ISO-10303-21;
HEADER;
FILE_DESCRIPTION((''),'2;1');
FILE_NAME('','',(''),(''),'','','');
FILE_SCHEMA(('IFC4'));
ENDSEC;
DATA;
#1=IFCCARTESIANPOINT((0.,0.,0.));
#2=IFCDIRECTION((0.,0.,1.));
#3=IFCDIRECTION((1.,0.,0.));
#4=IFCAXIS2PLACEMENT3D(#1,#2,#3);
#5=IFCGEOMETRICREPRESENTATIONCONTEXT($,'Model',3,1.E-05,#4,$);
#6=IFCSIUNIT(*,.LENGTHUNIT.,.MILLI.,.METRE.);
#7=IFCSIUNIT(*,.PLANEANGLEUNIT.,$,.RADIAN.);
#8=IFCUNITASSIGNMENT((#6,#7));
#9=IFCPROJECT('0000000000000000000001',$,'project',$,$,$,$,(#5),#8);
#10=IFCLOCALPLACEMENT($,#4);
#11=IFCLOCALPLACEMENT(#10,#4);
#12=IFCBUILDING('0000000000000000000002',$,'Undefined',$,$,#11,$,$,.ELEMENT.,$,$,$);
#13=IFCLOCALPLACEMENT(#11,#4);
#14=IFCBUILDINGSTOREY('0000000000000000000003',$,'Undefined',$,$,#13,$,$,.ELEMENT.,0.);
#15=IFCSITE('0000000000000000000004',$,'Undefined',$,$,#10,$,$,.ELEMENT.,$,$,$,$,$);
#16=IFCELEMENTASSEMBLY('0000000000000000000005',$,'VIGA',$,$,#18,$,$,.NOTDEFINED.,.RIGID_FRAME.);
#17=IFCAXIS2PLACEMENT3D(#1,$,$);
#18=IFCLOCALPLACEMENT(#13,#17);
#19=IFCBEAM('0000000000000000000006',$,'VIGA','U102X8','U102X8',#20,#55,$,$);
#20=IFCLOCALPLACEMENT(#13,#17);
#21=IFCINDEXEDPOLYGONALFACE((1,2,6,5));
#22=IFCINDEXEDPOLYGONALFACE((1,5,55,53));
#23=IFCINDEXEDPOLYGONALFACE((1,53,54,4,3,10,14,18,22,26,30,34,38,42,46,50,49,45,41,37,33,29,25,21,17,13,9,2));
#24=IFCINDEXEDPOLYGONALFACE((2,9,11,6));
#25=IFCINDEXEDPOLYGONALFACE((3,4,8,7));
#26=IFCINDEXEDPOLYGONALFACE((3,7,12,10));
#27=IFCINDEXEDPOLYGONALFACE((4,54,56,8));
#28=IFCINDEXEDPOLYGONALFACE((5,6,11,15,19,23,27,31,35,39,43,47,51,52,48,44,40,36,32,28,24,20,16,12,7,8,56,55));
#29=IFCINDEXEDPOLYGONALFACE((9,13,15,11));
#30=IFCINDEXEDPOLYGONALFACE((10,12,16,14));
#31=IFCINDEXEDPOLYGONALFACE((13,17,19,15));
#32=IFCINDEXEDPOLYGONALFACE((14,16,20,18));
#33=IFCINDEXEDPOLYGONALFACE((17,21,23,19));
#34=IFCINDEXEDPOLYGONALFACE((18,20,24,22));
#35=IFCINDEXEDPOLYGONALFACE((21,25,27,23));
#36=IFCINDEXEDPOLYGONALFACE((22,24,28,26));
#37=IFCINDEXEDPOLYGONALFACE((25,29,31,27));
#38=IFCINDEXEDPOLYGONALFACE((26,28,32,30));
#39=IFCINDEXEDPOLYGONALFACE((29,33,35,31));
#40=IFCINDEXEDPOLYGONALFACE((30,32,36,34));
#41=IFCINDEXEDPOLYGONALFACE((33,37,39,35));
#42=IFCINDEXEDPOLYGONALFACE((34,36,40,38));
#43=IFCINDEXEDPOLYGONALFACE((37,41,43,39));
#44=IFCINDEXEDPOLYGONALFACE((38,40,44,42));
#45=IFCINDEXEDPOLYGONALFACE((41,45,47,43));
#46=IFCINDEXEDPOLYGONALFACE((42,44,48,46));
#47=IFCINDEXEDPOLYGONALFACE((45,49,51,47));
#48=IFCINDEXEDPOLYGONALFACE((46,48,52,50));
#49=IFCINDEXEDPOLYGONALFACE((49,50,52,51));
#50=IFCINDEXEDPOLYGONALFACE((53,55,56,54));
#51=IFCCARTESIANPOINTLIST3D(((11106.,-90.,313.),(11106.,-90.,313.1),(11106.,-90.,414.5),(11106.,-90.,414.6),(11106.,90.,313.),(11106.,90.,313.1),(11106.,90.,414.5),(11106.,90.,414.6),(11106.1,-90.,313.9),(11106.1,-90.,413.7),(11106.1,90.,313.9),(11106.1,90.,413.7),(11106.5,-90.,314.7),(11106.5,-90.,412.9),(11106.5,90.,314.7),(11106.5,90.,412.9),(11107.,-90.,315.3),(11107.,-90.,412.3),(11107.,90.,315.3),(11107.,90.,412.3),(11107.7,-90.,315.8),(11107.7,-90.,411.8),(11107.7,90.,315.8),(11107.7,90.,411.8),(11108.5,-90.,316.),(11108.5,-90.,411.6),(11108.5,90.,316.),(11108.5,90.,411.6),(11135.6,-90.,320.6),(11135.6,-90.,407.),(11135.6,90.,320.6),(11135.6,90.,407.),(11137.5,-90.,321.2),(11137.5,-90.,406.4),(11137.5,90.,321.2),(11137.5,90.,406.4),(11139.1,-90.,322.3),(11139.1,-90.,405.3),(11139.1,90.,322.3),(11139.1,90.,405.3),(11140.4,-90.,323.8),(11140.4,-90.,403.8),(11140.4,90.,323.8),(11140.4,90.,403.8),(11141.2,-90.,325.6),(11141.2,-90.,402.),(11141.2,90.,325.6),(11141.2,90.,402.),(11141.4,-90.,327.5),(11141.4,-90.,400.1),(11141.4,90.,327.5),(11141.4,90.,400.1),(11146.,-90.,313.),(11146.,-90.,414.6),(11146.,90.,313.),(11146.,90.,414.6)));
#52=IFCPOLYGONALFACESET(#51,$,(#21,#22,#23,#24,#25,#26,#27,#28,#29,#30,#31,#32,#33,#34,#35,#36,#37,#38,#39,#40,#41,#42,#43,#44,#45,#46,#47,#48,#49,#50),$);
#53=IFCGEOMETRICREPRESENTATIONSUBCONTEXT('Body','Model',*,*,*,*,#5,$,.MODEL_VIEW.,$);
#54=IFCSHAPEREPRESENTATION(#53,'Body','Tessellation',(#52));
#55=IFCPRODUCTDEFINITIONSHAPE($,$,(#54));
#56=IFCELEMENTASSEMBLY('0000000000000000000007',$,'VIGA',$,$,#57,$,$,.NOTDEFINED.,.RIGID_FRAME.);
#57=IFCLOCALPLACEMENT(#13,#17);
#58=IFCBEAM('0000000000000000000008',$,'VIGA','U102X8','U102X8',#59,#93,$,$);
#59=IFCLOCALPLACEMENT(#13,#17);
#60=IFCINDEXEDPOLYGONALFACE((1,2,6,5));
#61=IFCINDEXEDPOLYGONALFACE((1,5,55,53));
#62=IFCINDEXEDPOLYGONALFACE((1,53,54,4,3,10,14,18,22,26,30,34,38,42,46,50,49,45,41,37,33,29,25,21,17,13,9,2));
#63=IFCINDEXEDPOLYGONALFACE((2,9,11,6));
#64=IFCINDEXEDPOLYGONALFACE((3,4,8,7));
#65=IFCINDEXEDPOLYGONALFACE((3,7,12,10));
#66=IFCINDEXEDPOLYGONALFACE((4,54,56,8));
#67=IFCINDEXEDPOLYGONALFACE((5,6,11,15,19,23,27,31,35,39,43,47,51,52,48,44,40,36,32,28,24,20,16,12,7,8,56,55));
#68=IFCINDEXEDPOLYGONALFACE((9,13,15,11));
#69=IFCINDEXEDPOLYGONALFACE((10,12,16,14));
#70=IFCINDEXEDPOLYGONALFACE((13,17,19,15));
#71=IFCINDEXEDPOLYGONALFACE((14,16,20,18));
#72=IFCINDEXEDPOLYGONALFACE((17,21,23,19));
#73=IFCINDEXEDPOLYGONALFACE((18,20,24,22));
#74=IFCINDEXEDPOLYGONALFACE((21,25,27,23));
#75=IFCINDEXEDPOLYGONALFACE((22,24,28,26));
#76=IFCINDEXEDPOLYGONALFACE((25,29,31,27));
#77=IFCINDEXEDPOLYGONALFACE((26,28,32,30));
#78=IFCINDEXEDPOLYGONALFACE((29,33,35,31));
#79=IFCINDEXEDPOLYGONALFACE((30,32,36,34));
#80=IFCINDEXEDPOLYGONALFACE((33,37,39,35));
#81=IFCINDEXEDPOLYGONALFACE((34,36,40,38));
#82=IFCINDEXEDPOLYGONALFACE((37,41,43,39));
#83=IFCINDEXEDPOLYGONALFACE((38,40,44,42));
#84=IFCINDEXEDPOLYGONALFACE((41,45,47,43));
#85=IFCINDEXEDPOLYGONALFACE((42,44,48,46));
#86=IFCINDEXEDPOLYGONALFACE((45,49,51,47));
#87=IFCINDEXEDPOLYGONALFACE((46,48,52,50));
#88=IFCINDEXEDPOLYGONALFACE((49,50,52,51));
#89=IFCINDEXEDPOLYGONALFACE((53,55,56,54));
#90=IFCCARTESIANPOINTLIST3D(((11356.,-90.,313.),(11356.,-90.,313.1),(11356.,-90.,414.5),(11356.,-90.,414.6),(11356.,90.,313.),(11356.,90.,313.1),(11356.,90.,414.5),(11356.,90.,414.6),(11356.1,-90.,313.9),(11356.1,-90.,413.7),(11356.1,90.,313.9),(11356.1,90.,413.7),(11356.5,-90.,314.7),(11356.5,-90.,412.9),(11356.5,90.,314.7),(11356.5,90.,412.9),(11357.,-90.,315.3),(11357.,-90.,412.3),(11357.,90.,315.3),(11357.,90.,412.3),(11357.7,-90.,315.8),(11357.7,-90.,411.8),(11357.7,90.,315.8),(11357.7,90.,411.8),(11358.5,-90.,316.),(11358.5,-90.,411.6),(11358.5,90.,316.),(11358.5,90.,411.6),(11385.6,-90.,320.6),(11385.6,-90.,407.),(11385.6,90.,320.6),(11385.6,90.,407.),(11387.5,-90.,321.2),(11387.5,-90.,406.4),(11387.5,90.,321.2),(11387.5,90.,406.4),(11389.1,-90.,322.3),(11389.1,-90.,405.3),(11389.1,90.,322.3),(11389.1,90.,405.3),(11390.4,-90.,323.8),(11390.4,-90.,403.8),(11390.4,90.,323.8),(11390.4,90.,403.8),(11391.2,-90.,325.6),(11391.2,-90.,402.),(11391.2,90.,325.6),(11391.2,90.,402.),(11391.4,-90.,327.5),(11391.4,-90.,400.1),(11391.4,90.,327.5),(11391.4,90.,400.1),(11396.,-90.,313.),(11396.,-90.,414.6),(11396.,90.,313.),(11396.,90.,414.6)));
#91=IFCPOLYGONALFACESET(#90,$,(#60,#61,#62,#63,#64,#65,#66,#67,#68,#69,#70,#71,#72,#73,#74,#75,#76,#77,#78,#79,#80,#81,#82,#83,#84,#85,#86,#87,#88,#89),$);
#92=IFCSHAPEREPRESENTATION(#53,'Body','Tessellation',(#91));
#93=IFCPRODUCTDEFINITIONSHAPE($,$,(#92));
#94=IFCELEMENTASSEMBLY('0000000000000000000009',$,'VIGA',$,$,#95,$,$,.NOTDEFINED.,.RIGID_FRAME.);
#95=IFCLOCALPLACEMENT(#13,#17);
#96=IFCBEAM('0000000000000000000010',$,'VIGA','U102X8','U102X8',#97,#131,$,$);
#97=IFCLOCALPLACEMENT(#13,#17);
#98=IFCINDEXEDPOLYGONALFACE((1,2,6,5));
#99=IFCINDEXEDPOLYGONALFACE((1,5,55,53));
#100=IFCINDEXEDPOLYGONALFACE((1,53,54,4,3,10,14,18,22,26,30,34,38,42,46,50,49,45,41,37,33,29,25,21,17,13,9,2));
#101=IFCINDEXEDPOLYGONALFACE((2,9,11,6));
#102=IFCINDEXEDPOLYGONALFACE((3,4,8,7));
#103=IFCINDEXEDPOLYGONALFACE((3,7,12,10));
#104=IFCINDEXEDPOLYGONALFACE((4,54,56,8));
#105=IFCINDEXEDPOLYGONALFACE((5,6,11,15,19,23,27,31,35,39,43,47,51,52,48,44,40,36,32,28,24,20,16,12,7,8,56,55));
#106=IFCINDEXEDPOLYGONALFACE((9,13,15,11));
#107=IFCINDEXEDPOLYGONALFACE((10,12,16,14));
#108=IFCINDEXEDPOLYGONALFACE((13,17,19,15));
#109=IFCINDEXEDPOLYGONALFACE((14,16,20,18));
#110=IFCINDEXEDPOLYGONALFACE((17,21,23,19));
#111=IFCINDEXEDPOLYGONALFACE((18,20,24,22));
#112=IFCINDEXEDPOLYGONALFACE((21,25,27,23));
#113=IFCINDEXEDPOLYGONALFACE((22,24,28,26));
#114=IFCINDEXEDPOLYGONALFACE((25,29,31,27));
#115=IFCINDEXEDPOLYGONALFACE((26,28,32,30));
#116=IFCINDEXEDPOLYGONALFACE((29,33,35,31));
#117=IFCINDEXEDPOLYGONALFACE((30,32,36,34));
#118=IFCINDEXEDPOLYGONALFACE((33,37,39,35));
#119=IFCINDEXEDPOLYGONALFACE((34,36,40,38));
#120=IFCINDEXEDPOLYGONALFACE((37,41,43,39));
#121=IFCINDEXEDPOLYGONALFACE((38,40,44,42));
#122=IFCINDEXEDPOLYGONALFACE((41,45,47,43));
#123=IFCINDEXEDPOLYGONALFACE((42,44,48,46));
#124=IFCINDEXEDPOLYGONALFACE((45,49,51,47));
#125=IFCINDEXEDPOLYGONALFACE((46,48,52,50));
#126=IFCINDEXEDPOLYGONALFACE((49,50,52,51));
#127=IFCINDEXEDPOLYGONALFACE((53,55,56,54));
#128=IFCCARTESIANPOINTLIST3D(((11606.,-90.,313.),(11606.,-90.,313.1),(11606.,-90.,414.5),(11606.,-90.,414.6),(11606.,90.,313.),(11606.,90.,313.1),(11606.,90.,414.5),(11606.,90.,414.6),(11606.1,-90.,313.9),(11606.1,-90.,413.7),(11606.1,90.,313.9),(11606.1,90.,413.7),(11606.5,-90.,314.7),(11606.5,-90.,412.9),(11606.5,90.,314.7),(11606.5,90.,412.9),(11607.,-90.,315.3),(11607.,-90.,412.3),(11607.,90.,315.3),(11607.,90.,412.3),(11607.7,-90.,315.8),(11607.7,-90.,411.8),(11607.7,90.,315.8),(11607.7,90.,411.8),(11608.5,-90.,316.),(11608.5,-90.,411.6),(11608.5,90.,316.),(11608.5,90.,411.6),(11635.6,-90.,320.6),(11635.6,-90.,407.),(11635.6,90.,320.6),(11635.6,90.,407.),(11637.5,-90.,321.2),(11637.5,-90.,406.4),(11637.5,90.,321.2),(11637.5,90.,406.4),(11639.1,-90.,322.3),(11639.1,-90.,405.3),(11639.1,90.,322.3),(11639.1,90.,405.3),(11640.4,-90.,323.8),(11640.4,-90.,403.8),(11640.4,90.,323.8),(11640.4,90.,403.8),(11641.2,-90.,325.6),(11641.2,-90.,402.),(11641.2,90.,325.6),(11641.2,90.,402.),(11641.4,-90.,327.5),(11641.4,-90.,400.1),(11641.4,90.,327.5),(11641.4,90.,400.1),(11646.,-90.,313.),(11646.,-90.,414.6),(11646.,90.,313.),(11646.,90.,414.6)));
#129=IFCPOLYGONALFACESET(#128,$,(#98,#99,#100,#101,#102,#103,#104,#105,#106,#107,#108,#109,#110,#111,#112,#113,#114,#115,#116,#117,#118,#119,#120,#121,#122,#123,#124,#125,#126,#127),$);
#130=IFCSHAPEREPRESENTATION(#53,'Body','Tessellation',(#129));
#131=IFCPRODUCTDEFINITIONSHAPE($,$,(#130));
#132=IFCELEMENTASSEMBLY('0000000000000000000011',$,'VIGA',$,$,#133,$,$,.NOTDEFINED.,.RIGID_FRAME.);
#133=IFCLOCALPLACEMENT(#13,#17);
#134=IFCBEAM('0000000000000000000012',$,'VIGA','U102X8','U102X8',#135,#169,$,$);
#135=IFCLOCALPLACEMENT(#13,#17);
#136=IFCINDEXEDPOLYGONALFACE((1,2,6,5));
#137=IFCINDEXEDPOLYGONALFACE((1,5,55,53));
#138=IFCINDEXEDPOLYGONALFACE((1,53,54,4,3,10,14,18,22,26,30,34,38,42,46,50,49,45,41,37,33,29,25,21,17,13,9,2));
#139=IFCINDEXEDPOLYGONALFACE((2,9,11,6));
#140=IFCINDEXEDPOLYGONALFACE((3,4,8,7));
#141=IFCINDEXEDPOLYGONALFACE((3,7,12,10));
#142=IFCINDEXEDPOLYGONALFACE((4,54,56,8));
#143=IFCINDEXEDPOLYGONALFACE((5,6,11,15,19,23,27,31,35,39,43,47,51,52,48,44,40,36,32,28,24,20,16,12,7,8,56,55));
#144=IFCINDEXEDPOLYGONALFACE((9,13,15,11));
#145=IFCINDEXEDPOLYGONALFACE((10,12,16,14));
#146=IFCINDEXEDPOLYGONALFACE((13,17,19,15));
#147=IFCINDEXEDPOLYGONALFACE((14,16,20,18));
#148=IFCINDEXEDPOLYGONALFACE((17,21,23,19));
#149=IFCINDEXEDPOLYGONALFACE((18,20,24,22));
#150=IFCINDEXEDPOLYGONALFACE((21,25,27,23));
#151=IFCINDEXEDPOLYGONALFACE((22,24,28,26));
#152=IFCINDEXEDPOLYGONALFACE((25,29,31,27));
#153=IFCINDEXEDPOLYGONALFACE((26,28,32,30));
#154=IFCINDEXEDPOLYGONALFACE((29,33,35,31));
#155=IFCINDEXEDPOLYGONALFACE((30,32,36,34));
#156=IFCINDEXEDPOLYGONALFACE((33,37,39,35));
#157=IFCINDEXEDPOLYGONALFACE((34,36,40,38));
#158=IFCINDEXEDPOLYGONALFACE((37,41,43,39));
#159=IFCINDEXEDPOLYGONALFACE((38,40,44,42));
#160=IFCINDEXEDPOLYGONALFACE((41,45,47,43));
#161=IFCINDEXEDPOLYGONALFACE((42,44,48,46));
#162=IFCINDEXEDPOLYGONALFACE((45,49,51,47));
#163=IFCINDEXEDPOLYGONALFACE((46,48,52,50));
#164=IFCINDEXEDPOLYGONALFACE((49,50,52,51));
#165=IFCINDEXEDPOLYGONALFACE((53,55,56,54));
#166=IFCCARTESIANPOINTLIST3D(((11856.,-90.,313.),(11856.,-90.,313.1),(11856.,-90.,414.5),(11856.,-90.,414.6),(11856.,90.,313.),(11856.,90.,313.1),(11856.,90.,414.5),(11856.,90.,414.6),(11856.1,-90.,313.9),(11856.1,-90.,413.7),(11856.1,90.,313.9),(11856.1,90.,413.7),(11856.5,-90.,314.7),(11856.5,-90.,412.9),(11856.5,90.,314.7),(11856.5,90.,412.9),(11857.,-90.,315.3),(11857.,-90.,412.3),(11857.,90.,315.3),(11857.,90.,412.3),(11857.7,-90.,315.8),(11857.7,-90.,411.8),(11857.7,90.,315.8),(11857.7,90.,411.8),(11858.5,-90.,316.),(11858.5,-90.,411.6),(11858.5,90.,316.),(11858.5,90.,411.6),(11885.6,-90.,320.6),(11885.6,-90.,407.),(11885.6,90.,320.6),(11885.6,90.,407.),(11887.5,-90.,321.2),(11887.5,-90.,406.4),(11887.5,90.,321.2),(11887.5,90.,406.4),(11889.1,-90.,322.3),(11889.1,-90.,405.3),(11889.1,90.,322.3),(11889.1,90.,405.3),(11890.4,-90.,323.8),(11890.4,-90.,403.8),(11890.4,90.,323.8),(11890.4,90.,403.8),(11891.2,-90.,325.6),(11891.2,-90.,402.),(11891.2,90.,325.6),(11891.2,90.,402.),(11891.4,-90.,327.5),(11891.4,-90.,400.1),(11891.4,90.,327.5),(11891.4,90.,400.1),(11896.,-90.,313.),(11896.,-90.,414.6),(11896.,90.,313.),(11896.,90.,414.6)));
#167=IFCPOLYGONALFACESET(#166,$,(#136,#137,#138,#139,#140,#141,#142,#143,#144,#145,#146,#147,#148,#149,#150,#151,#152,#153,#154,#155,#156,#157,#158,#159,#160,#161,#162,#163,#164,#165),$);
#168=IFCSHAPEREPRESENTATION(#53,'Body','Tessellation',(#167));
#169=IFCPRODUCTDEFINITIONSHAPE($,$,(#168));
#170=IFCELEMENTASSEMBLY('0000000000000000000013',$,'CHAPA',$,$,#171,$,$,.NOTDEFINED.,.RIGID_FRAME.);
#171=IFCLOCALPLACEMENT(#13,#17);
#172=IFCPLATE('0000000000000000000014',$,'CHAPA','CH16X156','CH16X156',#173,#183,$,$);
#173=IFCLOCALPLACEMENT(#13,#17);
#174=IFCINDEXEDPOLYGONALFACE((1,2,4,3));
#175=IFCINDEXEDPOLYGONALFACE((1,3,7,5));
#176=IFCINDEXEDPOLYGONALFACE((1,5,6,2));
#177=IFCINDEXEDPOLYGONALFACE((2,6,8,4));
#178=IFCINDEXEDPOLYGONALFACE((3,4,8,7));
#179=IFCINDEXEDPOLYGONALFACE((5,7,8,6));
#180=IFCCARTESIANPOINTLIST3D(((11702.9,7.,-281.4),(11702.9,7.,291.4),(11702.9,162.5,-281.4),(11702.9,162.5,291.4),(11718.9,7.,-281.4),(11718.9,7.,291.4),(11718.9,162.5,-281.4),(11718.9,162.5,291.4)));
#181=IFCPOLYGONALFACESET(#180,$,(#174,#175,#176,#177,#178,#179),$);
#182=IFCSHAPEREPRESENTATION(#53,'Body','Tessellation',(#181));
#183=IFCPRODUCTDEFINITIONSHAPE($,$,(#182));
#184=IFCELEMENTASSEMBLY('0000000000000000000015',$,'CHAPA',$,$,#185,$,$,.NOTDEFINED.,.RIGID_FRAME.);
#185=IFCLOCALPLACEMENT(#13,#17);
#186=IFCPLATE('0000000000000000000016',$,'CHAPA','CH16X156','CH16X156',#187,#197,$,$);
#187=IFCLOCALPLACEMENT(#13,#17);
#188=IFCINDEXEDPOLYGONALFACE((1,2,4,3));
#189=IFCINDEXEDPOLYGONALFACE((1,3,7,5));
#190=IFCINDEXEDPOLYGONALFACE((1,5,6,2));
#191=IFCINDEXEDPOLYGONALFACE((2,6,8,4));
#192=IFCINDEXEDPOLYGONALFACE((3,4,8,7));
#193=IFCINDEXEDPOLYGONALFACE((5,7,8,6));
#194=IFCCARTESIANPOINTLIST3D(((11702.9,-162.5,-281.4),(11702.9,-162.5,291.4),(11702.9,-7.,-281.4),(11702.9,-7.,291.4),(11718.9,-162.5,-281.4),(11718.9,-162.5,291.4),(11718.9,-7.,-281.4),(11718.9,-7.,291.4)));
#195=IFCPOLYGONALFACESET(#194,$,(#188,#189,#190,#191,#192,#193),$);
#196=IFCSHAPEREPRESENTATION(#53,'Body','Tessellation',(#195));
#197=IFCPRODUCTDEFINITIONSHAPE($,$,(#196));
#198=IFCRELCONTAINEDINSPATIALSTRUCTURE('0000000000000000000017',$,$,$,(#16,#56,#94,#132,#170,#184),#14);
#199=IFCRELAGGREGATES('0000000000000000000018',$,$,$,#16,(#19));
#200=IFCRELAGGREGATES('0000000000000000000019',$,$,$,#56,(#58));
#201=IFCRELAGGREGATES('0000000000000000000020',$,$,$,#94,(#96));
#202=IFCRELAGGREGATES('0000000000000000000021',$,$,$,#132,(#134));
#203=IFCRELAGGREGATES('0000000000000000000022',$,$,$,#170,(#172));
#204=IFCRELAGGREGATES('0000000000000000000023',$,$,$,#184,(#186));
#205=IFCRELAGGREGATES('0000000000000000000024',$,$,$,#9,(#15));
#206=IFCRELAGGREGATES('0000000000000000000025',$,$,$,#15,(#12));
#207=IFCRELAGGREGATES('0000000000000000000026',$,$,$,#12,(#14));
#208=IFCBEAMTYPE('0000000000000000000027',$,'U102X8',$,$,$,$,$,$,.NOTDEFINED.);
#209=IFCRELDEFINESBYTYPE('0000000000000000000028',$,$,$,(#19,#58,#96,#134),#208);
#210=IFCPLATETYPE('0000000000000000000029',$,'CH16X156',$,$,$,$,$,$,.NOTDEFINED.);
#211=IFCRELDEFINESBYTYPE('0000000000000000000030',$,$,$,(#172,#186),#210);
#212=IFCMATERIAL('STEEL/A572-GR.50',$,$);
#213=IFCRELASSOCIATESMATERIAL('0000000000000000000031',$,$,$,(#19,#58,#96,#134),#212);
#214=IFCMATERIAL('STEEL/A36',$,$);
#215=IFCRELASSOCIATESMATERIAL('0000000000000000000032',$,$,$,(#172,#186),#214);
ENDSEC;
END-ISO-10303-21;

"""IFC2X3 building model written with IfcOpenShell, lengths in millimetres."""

from ifc_helpers import new_model, si_unit, frame, origin_with_axes, origin_2d_with_axis, place, context, subcontext, project, spatial, polyline, u_section, outline, extrude, material, type_object, element, aggregate, save


model = new_model("IFC2X3")

# Units and contexts
model_context = context("Model", 3, precision=1e-05, world=origin_with_axes())
body_context = subcontext(model_context, "Body", "Model", "MODEL_VIEW")
ifc_project = project(units=[si_unit("LENGTHUNIT", "METRE", prefix="MILLI"), si_unit("PLANEANGLEUNIT", "RADIAN")], contexts=[model_context])

# Site, building, storey
site_placement = place(None, origin_with_axes())
site = spatial("IfcSite", under=ifc_project, at=site_placement, Name="Undefined", CompositionType="ELEMENT")
building_placement = place(site_placement, origin_with_axes())
building = spatial("IfcBuilding", under=site, at=building_placement, Name="Undefined", CompositionType="ELEMENT")
storey_placement = place(building_placement, origin_with_axes())
storey = spatial("IfcBuildingStorey", under=building, at=storey_placement, Name="Undefined", CompositionType="ELEMENT", Elevation=0.0)

# Element assemblies, beams
ifc_material_1 = material(Name="STEEL/A572-GR.50")
beam_type_1 = type_object("IfcBeamType", Name="U102X8", PredefinedType="NOTDEFINED")
assembly_1_placement = place(storey_placement, origin_with_axes())
assembly_1 = element("IfcElementAssembly", 1, at=assembly_1_placement, inside=storey, Name="VIGA", AssemblyPlace="NOTDEFINED", PredefinedType="RIGID_FRAME")
beam_1_placement = place(assembly_1_placement, frame((11126.0, 90.0, 363.8), z_axis=(0.0, 0.0, 1.0), x_axis=(0.0, -1.0, 0.0)))
beam_1 = element("IfcBeam", 2, at=beam_1_placement, type_object=beam_type_1, material=ifc_material_1, Name="VIGA", Description="U102X8", ObjectType="U102X8", context=body_context, shape_type="SweptSolid", body=[
    extrude(u_section(Depth=101.6, FlangeWidth=40.0, WebThickness=4.6, FlangeThickness=6.0, FilletRadius=7.0, EdgeRadius=3.0, FlangeSlope=0.16839, at=origin_2d_with_axis()), frame((180.0, 0.0, 0.0), z_axis=(-1.0, 0.0, 0.0), x_axis=(0.0, -1.0, 0.0)), (0.0, 0.0, 1.0), 180.0),
])
aggregate(assembly_1, [beam_1])
assembly_2_placement = place(storey_placement, origin_with_axes())
assembly_2 = element("IfcElementAssembly", 3, at=assembly_2_placement, inside=storey, Name="VIGA", AssemblyPlace="NOTDEFINED", PredefinedType="RIGID_FRAME")
beam_2_placement = place(assembly_2_placement, frame((11376.0, 90.0, 363.8), z_axis=(0.0, 0.0, 1.0), x_axis=(0.0, -1.0, 0.0)))
beam_2 = element("IfcBeam", 4, at=beam_2_placement, type_object=beam_type_1, material=ifc_material_1, Name="VIGA", Description="U102X8", ObjectType="U102X8", context=body_context, shape_type="SweptSolid", body=[
    extrude(u_section(Depth=101.6, FlangeWidth=40.0, WebThickness=4.6, FlangeThickness=6.0, FilletRadius=7.0, EdgeRadius=3.0, FlangeSlope=0.16839, at=origin_2d_with_axis()), frame((180.0, 0.0, 0.0), z_axis=(-1.0, 0.0, 0.0), x_axis=(0.0, -1.0, 0.0)), (0.0, 0.0, 1.0), 180.0),
])
aggregate(assembly_2, [beam_2])
assembly_3_placement = place(storey_placement, origin_with_axes())
assembly_3 = element("IfcElementAssembly", 5, at=assembly_3_placement, inside=storey, Name="VIGA", AssemblyPlace="NOTDEFINED", PredefinedType="RIGID_FRAME")
beam_3_placement = place(assembly_3_placement, frame((11626.0, 90.0, 363.8), z_axis=(0.0, 0.0, 1.0), x_axis=(0.0, -1.0, 0.0)))
beam_3 = element("IfcBeam", 6, at=beam_3_placement, type_object=beam_type_1, material=ifc_material_1, Name="VIGA", Description="U102X8", ObjectType="U102X8", context=body_context, shape_type="SweptSolid", body=[
    extrude(u_section(Depth=101.6, FlangeWidth=40.0, WebThickness=4.6, FlangeThickness=6.0, FilletRadius=7.0, EdgeRadius=3.0, FlangeSlope=0.16839, at=origin_2d_with_axis()), frame((180.0, 0.0, 0.0), z_axis=(-1.0, 0.0, 0.0), x_axis=(0.0, -1.0, 0.0)), (0.0, 0.0, 1.0), 180.0),
])
aggregate(assembly_3, [beam_3])
assembly_4_placement = place(storey_placement, origin_with_axes())
assembly_4 = element("IfcElementAssembly", 7, at=assembly_4_placement, inside=storey, Name="VIGA", AssemblyPlace="NOTDEFINED", PredefinedType="RIGID_FRAME")
beam_4_placement = place(assembly_4_placement, frame((11876.0, 90.0, 363.8), z_axis=(0.0, 0.0, 1.0), x_axis=(0.0, -1.0, 0.0)))
beam_4 = element("IfcBeam", 8, at=beam_4_placement, type_object=beam_type_1, material=ifc_material_1, Name="VIGA", Description="U102X8", ObjectType="U102X8", context=body_context, shape_type="SweptSolid", body=[
    extrude(u_section(Depth=101.6, FlangeWidth=40.0, WebThickness=4.6, FlangeThickness=6.0, FilletRadius=7.0, EdgeRadius=3.0, FlangeSlope=0.16839, at=origin_2d_with_axis()), frame((180.0, 0.0, 0.0), z_axis=(-1.0, 0.0, 0.0), x_axis=(0.0, -1.0, 0.0)), (0.0, 0.0, 1.0), 180.0),
])
aggregate(assembly_4, [beam_4])

# Element assemblies, plates
assembly_5_placement = place(storey_placement, origin_with_axes())
assembly_5 = element("IfcElementAssembly", 9, at=assembly_5_placement, inside=storey, Name="CHAPA", AssemblyPlace="NOTDEFINED", PredefinedType="RIGID_FRAME")
ifc_material_2 = material(Name="STEEL/A36")
plate_type = type_object("IfcPlateType", Name="CH16X156", PredefinedType="NOTDEFINED")
plate_1_placement = place(assembly_5_placement, frame((11710.9, 162.5, 291.4), z_axis=(1.0, 0.0, 0.0), x_axis=(0.0, -1.0, 0.0)))
plate_1 = element("IfcPlate", 10, at=plate_1_placement, type_object=plate_type, material=ifc_material_2, Name="CHAPA", Description="CH16X156", ObjectType="CH16X156", context=body_context, shape_type="SweptSolid", body=[
    extrude(outline(polyline([(0.0, 0.0), (155.5, 0.0), (155.5, 572.8), (0.0, 572.8), (0.0, 0.0)])), frame((0.0, 0.0, -8.0), z_axis=(0.0, 0.0, 1.0), x_axis=(1.0, 0.0, 0.0)), (0.0, 0.0, 1.0), 16.0),
])
aggregate(assembly_5, [plate_1])
assembly_6_placement = place(storey_placement, origin_with_axes())
assembly_6 = element("IfcElementAssembly", 11, at=assembly_6_placement, inside=storey, Name="CHAPA", AssemblyPlace="NOTDEFINED", PredefinedType="RIGID_FRAME")
plate_2_placement = place(assembly_6_placement, frame((11710.9, -7.0, 291.4), z_axis=(1.0, 0.0, 0.0), x_axis=(0.0, -1.0, 0.0)))
plate_2 = element("IfcPlate", 12, at=plate_2_placement, type_object=plate_type, material=ifc_material_2, Name="CHAPA", Description="CH16X156", ObjectType="CH16X156", context=body_context, shape_type="SweptSolid", body=[
    extrude(outline(polyline([(0.0, 0.0), (155.5, 0.0), (155.5, 572.8), (0.0, 572.8), (0.0, 0.0)])), frame((0.0, 0.0, -8.0), z_axis=(0.0, 0.0, 1.0), x_axis=(1.0, 0.0, 0.0)), (0.0, 0.0, 1.0), 16.0),
])
aggregate(assembly_6, [plate_2])

save(model, "model.ifc")
